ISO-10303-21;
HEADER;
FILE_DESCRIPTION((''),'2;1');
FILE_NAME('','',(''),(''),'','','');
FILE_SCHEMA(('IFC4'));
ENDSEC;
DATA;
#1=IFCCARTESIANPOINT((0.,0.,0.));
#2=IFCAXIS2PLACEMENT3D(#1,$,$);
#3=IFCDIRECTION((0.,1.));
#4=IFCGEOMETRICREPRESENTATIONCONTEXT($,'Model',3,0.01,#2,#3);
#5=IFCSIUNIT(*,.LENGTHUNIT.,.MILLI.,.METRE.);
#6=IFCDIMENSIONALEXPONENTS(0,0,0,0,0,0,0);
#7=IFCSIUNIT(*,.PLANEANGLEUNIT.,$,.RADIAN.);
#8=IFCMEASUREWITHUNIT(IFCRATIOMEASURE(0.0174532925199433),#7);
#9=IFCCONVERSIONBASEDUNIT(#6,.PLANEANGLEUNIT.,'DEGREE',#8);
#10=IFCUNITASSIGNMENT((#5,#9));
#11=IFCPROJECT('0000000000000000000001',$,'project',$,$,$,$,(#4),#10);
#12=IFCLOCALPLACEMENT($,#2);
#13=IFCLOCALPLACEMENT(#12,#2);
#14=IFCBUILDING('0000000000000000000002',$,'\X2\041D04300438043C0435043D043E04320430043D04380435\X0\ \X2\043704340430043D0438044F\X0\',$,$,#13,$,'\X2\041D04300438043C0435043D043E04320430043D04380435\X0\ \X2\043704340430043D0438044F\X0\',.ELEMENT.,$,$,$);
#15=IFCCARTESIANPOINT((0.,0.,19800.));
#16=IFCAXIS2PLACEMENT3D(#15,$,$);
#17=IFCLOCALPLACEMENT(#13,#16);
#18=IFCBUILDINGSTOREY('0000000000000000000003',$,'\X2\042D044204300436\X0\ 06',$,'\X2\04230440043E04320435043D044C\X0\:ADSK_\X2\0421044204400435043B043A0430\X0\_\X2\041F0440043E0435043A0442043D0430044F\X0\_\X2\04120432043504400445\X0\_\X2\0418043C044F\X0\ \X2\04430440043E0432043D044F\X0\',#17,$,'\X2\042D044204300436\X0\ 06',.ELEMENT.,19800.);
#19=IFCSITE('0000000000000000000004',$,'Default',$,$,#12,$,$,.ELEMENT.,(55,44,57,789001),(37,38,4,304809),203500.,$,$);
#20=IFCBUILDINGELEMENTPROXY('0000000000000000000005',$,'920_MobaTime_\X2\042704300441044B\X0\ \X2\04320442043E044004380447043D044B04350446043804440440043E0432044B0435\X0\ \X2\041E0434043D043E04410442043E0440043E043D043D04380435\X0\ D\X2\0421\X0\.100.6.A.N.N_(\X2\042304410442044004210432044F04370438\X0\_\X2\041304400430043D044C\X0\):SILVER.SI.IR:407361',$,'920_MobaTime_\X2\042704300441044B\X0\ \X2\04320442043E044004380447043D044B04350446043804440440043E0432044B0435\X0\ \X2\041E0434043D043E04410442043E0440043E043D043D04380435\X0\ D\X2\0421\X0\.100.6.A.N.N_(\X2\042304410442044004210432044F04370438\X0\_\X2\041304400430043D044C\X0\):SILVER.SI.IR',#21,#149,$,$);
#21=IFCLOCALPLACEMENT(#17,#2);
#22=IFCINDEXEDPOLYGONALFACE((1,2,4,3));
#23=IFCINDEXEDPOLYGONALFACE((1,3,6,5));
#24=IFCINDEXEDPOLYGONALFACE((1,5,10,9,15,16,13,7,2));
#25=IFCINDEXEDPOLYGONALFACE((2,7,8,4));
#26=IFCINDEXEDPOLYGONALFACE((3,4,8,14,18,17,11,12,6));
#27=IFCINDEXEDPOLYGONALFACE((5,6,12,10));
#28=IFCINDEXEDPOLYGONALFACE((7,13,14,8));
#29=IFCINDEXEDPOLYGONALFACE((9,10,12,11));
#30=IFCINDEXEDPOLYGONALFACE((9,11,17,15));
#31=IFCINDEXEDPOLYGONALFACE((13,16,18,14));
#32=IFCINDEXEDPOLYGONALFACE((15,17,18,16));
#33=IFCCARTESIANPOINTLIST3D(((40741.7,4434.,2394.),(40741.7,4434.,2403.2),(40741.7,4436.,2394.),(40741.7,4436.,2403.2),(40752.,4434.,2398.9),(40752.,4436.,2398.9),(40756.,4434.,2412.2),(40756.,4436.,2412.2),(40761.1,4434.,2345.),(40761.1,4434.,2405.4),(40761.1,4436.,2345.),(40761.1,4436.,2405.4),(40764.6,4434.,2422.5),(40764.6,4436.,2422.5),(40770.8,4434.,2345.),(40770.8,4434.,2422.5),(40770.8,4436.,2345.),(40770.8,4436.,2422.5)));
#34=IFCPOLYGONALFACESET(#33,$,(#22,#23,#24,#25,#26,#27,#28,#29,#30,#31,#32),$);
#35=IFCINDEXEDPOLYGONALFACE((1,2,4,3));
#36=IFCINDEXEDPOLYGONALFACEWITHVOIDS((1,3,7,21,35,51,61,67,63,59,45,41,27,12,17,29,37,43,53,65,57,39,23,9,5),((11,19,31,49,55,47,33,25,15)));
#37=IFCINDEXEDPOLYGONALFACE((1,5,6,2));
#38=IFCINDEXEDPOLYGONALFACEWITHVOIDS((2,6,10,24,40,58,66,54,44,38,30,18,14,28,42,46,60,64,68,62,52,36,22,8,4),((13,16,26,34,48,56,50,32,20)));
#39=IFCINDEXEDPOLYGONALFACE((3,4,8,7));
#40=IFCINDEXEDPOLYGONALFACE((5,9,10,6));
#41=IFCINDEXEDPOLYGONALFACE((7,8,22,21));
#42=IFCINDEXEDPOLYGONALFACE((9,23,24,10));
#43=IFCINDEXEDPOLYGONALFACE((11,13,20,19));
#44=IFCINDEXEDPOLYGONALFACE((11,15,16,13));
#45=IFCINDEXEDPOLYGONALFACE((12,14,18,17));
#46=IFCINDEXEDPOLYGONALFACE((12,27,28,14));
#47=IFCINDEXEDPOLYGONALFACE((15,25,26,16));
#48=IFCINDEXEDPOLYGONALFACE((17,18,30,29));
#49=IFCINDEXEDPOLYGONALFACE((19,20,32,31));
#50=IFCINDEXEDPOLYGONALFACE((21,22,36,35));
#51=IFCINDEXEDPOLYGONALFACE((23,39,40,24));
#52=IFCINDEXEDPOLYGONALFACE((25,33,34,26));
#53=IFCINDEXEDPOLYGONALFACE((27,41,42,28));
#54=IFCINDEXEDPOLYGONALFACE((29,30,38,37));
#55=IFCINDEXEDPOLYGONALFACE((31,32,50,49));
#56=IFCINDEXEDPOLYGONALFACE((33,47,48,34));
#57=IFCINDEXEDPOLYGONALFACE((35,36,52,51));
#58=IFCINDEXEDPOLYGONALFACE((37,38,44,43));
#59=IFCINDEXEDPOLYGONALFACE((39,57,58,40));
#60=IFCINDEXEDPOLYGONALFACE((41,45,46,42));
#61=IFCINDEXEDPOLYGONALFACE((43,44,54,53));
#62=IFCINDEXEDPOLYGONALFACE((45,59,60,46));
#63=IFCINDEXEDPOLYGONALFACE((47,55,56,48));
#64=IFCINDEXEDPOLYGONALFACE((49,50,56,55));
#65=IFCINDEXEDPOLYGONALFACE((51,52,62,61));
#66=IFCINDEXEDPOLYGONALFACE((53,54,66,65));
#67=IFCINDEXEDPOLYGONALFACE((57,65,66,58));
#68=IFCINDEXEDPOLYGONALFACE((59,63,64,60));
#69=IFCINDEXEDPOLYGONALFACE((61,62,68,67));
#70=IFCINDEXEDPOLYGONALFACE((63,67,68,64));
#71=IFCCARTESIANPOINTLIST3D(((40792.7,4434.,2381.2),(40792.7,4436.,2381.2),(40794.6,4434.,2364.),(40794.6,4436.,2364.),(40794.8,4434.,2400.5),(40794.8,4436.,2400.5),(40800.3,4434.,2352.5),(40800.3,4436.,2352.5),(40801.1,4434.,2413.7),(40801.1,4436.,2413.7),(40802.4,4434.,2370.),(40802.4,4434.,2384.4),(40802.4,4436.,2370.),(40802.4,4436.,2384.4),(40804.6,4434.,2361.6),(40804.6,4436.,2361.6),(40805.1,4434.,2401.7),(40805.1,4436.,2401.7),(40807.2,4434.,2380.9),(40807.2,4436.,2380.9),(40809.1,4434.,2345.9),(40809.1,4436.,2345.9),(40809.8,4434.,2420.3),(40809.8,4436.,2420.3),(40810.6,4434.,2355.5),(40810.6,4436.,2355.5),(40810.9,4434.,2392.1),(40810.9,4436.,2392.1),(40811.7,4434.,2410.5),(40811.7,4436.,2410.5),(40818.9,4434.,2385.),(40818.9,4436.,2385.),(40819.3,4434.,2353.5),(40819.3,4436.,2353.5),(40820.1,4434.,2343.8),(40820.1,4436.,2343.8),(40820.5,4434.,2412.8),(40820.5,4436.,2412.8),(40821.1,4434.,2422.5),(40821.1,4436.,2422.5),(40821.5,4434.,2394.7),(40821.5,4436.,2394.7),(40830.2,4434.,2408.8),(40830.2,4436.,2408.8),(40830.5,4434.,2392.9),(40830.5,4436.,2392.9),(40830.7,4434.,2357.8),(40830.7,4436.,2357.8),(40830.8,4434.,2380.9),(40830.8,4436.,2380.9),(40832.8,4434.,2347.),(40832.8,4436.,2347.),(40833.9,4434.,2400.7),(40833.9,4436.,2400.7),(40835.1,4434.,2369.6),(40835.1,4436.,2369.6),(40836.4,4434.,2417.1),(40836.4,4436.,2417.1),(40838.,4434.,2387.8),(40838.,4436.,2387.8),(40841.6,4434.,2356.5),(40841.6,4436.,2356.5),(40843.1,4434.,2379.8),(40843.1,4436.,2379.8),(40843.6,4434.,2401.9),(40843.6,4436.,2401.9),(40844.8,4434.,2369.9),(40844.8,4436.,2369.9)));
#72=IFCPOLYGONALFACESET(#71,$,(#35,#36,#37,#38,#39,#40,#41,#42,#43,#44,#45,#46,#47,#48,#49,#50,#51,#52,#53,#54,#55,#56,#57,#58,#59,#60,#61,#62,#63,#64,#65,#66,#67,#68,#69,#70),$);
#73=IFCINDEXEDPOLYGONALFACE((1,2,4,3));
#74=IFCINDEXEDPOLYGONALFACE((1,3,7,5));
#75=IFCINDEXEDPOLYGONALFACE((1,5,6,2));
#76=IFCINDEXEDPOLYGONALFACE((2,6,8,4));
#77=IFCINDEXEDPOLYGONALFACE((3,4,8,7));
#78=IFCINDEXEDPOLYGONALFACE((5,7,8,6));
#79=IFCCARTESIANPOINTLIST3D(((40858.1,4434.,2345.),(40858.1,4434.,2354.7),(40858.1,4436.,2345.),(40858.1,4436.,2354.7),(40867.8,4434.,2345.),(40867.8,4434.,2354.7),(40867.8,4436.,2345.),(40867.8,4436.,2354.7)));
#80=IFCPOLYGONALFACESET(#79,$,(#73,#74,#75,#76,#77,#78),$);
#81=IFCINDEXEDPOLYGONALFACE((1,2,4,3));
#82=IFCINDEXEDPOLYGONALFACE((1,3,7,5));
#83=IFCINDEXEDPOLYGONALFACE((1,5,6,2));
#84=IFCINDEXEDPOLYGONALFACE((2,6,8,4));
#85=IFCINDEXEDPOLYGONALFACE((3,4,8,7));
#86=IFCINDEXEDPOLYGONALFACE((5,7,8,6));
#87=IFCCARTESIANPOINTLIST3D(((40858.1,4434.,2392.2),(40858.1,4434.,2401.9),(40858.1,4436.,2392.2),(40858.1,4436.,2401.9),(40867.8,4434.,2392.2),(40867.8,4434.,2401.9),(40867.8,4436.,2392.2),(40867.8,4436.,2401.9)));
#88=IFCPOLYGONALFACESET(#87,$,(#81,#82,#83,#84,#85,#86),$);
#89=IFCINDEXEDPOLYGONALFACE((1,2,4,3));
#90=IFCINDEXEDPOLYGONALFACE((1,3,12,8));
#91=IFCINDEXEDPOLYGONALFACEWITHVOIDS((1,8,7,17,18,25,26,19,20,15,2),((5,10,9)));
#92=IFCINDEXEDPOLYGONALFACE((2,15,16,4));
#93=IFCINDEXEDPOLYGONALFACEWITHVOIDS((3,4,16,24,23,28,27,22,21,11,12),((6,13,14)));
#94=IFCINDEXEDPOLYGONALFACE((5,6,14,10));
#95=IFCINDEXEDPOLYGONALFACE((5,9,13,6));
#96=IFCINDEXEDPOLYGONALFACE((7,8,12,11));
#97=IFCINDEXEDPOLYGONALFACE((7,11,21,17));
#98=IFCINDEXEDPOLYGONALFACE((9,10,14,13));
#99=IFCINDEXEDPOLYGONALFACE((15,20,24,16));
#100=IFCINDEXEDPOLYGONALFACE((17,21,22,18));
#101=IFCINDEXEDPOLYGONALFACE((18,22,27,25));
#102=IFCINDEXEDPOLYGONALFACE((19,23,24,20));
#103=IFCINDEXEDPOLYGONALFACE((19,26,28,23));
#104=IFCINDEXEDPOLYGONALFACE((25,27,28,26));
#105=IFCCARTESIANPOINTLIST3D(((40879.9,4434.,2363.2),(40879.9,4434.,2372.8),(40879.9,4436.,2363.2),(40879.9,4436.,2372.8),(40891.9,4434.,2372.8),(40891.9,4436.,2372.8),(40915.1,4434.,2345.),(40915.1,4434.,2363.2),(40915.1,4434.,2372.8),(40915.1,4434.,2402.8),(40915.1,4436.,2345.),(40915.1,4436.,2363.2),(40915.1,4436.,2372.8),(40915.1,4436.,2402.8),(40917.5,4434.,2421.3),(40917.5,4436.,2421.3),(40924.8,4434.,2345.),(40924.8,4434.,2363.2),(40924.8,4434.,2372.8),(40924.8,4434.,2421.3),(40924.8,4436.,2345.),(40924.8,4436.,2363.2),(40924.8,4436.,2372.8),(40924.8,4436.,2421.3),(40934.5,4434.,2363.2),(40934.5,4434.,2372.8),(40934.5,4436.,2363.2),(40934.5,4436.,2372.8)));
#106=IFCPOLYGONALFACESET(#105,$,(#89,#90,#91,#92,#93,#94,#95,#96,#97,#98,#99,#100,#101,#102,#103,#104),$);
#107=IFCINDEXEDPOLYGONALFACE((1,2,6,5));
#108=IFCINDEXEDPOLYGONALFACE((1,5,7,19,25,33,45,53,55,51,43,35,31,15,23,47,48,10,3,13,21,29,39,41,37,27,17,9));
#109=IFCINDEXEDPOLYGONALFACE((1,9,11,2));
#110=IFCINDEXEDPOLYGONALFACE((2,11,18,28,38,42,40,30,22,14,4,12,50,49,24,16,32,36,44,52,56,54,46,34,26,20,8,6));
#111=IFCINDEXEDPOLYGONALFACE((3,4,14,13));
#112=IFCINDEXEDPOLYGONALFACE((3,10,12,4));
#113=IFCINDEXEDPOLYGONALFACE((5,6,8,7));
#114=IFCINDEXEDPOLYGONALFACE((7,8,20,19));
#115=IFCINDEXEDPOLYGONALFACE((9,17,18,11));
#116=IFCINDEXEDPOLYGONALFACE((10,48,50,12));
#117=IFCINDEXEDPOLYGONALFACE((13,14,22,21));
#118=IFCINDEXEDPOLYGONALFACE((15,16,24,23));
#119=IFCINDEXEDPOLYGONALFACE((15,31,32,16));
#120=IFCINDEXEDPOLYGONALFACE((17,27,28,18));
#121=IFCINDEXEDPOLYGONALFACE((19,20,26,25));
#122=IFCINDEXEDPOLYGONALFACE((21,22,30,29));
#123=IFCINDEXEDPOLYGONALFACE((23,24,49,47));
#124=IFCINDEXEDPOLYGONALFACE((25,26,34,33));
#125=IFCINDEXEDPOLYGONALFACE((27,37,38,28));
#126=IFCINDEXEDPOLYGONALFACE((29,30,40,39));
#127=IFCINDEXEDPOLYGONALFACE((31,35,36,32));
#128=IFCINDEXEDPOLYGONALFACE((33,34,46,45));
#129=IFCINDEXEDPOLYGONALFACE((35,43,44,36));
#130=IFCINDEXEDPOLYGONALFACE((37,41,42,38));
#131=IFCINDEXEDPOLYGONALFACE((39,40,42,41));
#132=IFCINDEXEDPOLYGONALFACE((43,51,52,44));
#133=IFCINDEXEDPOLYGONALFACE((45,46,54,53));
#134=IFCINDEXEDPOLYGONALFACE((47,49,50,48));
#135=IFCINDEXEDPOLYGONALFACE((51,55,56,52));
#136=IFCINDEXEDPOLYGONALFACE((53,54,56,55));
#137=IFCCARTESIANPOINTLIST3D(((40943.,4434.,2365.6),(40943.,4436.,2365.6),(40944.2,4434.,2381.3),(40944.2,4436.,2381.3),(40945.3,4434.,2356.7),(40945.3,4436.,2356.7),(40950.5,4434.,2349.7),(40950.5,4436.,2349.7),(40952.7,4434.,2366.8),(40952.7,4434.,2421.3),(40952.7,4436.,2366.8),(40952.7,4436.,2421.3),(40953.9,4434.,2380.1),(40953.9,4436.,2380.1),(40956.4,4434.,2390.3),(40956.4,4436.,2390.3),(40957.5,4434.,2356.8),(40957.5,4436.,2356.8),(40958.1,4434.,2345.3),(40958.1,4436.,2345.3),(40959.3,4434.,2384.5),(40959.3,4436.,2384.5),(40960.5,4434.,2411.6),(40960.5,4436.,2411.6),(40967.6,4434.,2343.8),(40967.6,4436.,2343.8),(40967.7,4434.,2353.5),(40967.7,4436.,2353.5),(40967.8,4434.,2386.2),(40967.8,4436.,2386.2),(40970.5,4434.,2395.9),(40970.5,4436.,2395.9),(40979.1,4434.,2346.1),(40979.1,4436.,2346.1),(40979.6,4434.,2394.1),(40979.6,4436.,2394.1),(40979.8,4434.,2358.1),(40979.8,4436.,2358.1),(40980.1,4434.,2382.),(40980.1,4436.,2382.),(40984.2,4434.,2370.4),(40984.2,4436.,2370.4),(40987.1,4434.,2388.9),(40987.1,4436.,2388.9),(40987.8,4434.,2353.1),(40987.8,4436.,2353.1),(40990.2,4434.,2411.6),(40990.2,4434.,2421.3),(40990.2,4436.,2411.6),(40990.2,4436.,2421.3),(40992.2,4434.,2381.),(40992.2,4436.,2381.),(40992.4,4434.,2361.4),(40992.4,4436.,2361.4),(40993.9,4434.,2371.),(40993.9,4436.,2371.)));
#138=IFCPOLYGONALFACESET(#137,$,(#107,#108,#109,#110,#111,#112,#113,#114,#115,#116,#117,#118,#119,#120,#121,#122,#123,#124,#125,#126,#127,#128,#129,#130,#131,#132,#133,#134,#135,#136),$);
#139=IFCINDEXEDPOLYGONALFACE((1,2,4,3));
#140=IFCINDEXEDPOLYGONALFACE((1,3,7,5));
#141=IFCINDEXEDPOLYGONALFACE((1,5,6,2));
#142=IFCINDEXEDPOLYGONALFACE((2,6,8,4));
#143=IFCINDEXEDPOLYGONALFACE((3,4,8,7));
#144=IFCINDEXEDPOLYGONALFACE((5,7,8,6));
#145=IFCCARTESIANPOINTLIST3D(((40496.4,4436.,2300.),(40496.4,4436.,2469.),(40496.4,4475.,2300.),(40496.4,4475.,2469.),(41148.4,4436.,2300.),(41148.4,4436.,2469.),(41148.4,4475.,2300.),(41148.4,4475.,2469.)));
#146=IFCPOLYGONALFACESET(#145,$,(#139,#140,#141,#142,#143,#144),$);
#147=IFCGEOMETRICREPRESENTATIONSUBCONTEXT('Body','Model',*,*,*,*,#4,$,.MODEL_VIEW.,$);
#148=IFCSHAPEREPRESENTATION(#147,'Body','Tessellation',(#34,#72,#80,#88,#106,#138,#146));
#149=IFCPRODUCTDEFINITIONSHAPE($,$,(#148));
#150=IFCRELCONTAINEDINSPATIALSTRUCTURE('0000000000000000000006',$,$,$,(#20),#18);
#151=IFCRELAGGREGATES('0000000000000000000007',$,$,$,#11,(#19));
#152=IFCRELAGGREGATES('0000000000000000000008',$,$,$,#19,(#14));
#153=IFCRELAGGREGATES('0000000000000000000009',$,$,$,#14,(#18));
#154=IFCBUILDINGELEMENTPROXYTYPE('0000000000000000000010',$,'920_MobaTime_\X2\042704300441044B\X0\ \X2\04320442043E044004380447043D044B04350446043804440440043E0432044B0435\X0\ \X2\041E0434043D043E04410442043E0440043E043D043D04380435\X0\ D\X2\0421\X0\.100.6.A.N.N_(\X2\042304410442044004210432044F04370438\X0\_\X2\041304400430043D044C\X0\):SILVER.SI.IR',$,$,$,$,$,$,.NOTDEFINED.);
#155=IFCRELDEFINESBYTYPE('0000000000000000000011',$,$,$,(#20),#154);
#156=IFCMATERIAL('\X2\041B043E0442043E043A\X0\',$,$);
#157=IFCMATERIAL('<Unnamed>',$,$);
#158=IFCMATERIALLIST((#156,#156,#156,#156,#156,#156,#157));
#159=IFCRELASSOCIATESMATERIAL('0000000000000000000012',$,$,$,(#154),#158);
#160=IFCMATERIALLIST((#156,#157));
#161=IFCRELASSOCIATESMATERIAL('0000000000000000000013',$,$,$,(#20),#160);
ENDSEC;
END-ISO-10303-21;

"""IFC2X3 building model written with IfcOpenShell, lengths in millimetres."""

from ifc_helpers import new_model, entity, si_unit, converted_unit, direction, frame, origin, origin_2d_with_axis, place, context, subcontext, project, spatial, polyline, rectangle, outline, extrude, source, transform, mapped, material, material_list, type_object, type_shapes, element, save


model = new_model("IFC2X3")

# Units and contexts
model_context = context("Model", 3, precision=0.01, world=origin(), true_north=direction((0.0, 1.0)))
body_context = subcontext(model_context, "Body", "Model", "MODEL_VIEW")
ifc_project = project(units=[si_unit("LENGTHUNIT", "METRE", prefix="MILLI"), converted_unit("PLANEANGLEUNIT", "DEGREE", entity("IfcRatioMeasure", 0.0174532925199433), si_unit("PLANEANGLEUNIT", "RADIAN"), dimensions=[0, 0, 0, 0, 0, 0, 0])], contexts=[model_context])

# Site, building, storey
site_placement = place(None, frame((0.0, 0.0, 0.0)))
site = spatial("IfcSite", under=ifc_project, at=site_placement, Name="Default", CompositionType="ELEMENT", RefLatitude=(55, 44, 57, 789001), RefLongitude=(37, 38, 4, 304809), RefElevation=203500.0)
building_placement = place(site_placement, origin())
building = spatial("IfcBuilding", under=site, at=building_placement, Name="Наименование здания", LongName="Наименование здания", CompositionType="ELEMENT")
storey_placement = place(building_placement, frame((0.0, 0.0, 19800.0)))
storey = spatial("IfcBuildingStorey", under=building, at=storey_placement, Name="Этаж 06", ObjectType="Уровень:ADSK_Стрелка_Проектная_Вверх_Имя уровня", LongName="Этаж 06", CompositionType="ELEMENT", Elevation=19800.0)

# Building element proxy
ifc_material_1 = material(Name="Лоток")
ifc_material_2 = material(Name="<Unnamed>")
ifc_material_list_1 = material_list([ifc_material_1, ifc_material_1, ifc_material_1, ifc_material_1, ifc_material_1, ifc_material_1, ifc_material_2])
building_element_proxy_type_1 = type_object("IfcBuildingElementProxyType", Name="920_MobaTime_Часы вторичныецифровые Односторонние DС.100.6.A.N.N_(УстрСвязи_Грань):SILVER.SI.IR", PredefinedType="NOTDEFINED", material=ifc_material_list_1)
shared_shape_1 = source(origin(), body_context, "Body", "SweptSolid", [
    extrude(outline(polyline([(-49.3, -13.1), (28.2, -13.1), (28.2, -6.8), (17.9, 1.8), (8.9, 16.0), (-0.3, 16.0), (4.6, 5.8), (11.1, -3.4), (-49.3, -3.4), (-49.3, -13.1)])), frame((-64.6, 9.8, 39.0), z_axis=(0.0, 0.0, 1.0), x_axis=(0.0, 1.0, 0.0)), (0.0, 0.0, 1.0), 2.0),
    extrude(outline(polyline([(2.2, -27.6), (19.0, -27.6), (30.5, -16.1), (33.3, -4.9), (31.0, 5.8), (21.8, 17.2), (5.2, 27.3), (-11.1, 33.0), (-24.0, 32.7), (-33.6, 27.6), (-40.3, 18.6), (-42.8, 5.7), (-38.0, -6.3), (-27.2, -15.0), (-17.5, -17.7), (-8.2, -16.4), (-0.3, -11.9), (5.1, -4.5), (7.3, 6.2), (4.0, 17.2), (18.5, 7.3), (23.6, -2.4), (22.0, -11.4), (14.2, -18.4), (5.3, -18.3), (2.2, -27.6)]), holes=[polyline([(-9.0, 23.3), (-1.3, 14.4), (-2.6, 2.0), (-11.4, -7.0), (-23.4, -6.1), (-32.2, 2.9), (-31.2, 15.1), (-25.6, 22.1), (-17.5, 24.9), (-9.0, 23.3)])]), frame((-2.7, 3.6, 39.0), z_axis=(0.0, 0.0, 1.0), x_axis=(-0.427649, 0.903945, 0.0)), (0.0, 0.0, 1.0), 2.0),
    extrude(rectangle(XDim=9.7, YDim=9.7, at=origin_2d_with_axis()), frame((40.6, -34.7, 39.0)), (0.0, 0.0, 1.0), 2.0),
    extrude(rectangle(XDim=9.7, YDim=9.7, at=origin_2d_with_axis()), frame((40.6, 12.6, 39.0)), (0.0, 0.0, 1.0), 2.0),
    extrude(outline(polyline([(-0.9, -28.1), (8.8, -28.1), (8.8, -9.9), (18.5, -9.9), (18.5, -0.2), (8.8, -0.2), (8.8, 48.3), (1.5, 48.3), (-36.0, -0.2), (-36.0, -9.9), (-0.9, -9.9), (-0.9, -28.1)]), holes=[polyline([(-0.9, -0.2), (-24.1, -0.2), (-0.9, 29.7), (-0.9, -0.2)])]), frame((93.6, -11.4, 39.0)), (0.0, 0.0, 1.0), 2.0),
    extrude(outline(polyline([(3.3, -28.3), (12.5, -28.3), (20.5, -25.0), (26.8, -18.8), (30.7, -10.0), (31.4, 1.6), (26.9, 11.8), (20.1, 18.4), (11.1, 22.3), (1.0, 23.3), (-7.9, 20.4), (-14.9, 14.5), (-18.9, 6.2), (-17.1, -9.0), (-36.7, 0.5), (-29.1, 29.3), (-38.5, 31.7), (-48.1, -4.6), (-11.6, -23.0), (-8.0, -14.0), (-10.8, -7.6), (-10.2, 1.1), (-3.0, 11.8), (9.2, 12.8), (20.0, 5.4), (21.3, -7.5), (15.5, -16.4), (4.6, -18.6), (3.3, -28.3)])), frame((147.1, -8.5, 39.0), z_axis=(0.0, 0.0, 1.0), x_axis=(0.256974, -0.966418, 0.0)), (0.0, 0.0, 1.0), 2.0),
    extrude(rectangle(XDim=652.0, YDim=169.0, at=origin_2d_with_axis()), frame((0.0, 0.0, 0.0), z_axis=(0.0, 0.0, 1.0), x_axis=(-1.0, 0.0, 0.0)), (0.0, 0.0, 1.0), 39.0),
])
type_shapes(building_element_proxy_type_1, [shared_shape_1])
ifc_material_list_2 = material_list([ifc_material_1, ifc_material_2])
proxy_1_placement = place(storey_placement, frame((40822.4, 4475.0, 2384.5), z_axis=(0.0, -1.0, 0.0), x_axis=(1.0, 0.0, 0.0)))
element("IfcBuildingElementProxy", 1, at=proxy_1_placement, inside=storey, type_object=building_element_proxy_type_1, material=ifc_material_list_2, Name="920_MobaTime_Часы вторичныецифровые Односторонние DС.100.6.A.N.N_(УстрСвязи_Грань):SILVER.SI.IR:407361", ObjectType="920_MobaTime_Часы вторичныецифровые Односторонние DС.100.6.A.N.N_(УстрСвязи_Грань):SILVER.SI.IR", context=body_context, shape_type="MappedRepresentation", body=[
    mapped(shared_shape_1, transform((0.0, 0.0, 0.0), scale=1.0)),
])

save(model, "model.ifc")
